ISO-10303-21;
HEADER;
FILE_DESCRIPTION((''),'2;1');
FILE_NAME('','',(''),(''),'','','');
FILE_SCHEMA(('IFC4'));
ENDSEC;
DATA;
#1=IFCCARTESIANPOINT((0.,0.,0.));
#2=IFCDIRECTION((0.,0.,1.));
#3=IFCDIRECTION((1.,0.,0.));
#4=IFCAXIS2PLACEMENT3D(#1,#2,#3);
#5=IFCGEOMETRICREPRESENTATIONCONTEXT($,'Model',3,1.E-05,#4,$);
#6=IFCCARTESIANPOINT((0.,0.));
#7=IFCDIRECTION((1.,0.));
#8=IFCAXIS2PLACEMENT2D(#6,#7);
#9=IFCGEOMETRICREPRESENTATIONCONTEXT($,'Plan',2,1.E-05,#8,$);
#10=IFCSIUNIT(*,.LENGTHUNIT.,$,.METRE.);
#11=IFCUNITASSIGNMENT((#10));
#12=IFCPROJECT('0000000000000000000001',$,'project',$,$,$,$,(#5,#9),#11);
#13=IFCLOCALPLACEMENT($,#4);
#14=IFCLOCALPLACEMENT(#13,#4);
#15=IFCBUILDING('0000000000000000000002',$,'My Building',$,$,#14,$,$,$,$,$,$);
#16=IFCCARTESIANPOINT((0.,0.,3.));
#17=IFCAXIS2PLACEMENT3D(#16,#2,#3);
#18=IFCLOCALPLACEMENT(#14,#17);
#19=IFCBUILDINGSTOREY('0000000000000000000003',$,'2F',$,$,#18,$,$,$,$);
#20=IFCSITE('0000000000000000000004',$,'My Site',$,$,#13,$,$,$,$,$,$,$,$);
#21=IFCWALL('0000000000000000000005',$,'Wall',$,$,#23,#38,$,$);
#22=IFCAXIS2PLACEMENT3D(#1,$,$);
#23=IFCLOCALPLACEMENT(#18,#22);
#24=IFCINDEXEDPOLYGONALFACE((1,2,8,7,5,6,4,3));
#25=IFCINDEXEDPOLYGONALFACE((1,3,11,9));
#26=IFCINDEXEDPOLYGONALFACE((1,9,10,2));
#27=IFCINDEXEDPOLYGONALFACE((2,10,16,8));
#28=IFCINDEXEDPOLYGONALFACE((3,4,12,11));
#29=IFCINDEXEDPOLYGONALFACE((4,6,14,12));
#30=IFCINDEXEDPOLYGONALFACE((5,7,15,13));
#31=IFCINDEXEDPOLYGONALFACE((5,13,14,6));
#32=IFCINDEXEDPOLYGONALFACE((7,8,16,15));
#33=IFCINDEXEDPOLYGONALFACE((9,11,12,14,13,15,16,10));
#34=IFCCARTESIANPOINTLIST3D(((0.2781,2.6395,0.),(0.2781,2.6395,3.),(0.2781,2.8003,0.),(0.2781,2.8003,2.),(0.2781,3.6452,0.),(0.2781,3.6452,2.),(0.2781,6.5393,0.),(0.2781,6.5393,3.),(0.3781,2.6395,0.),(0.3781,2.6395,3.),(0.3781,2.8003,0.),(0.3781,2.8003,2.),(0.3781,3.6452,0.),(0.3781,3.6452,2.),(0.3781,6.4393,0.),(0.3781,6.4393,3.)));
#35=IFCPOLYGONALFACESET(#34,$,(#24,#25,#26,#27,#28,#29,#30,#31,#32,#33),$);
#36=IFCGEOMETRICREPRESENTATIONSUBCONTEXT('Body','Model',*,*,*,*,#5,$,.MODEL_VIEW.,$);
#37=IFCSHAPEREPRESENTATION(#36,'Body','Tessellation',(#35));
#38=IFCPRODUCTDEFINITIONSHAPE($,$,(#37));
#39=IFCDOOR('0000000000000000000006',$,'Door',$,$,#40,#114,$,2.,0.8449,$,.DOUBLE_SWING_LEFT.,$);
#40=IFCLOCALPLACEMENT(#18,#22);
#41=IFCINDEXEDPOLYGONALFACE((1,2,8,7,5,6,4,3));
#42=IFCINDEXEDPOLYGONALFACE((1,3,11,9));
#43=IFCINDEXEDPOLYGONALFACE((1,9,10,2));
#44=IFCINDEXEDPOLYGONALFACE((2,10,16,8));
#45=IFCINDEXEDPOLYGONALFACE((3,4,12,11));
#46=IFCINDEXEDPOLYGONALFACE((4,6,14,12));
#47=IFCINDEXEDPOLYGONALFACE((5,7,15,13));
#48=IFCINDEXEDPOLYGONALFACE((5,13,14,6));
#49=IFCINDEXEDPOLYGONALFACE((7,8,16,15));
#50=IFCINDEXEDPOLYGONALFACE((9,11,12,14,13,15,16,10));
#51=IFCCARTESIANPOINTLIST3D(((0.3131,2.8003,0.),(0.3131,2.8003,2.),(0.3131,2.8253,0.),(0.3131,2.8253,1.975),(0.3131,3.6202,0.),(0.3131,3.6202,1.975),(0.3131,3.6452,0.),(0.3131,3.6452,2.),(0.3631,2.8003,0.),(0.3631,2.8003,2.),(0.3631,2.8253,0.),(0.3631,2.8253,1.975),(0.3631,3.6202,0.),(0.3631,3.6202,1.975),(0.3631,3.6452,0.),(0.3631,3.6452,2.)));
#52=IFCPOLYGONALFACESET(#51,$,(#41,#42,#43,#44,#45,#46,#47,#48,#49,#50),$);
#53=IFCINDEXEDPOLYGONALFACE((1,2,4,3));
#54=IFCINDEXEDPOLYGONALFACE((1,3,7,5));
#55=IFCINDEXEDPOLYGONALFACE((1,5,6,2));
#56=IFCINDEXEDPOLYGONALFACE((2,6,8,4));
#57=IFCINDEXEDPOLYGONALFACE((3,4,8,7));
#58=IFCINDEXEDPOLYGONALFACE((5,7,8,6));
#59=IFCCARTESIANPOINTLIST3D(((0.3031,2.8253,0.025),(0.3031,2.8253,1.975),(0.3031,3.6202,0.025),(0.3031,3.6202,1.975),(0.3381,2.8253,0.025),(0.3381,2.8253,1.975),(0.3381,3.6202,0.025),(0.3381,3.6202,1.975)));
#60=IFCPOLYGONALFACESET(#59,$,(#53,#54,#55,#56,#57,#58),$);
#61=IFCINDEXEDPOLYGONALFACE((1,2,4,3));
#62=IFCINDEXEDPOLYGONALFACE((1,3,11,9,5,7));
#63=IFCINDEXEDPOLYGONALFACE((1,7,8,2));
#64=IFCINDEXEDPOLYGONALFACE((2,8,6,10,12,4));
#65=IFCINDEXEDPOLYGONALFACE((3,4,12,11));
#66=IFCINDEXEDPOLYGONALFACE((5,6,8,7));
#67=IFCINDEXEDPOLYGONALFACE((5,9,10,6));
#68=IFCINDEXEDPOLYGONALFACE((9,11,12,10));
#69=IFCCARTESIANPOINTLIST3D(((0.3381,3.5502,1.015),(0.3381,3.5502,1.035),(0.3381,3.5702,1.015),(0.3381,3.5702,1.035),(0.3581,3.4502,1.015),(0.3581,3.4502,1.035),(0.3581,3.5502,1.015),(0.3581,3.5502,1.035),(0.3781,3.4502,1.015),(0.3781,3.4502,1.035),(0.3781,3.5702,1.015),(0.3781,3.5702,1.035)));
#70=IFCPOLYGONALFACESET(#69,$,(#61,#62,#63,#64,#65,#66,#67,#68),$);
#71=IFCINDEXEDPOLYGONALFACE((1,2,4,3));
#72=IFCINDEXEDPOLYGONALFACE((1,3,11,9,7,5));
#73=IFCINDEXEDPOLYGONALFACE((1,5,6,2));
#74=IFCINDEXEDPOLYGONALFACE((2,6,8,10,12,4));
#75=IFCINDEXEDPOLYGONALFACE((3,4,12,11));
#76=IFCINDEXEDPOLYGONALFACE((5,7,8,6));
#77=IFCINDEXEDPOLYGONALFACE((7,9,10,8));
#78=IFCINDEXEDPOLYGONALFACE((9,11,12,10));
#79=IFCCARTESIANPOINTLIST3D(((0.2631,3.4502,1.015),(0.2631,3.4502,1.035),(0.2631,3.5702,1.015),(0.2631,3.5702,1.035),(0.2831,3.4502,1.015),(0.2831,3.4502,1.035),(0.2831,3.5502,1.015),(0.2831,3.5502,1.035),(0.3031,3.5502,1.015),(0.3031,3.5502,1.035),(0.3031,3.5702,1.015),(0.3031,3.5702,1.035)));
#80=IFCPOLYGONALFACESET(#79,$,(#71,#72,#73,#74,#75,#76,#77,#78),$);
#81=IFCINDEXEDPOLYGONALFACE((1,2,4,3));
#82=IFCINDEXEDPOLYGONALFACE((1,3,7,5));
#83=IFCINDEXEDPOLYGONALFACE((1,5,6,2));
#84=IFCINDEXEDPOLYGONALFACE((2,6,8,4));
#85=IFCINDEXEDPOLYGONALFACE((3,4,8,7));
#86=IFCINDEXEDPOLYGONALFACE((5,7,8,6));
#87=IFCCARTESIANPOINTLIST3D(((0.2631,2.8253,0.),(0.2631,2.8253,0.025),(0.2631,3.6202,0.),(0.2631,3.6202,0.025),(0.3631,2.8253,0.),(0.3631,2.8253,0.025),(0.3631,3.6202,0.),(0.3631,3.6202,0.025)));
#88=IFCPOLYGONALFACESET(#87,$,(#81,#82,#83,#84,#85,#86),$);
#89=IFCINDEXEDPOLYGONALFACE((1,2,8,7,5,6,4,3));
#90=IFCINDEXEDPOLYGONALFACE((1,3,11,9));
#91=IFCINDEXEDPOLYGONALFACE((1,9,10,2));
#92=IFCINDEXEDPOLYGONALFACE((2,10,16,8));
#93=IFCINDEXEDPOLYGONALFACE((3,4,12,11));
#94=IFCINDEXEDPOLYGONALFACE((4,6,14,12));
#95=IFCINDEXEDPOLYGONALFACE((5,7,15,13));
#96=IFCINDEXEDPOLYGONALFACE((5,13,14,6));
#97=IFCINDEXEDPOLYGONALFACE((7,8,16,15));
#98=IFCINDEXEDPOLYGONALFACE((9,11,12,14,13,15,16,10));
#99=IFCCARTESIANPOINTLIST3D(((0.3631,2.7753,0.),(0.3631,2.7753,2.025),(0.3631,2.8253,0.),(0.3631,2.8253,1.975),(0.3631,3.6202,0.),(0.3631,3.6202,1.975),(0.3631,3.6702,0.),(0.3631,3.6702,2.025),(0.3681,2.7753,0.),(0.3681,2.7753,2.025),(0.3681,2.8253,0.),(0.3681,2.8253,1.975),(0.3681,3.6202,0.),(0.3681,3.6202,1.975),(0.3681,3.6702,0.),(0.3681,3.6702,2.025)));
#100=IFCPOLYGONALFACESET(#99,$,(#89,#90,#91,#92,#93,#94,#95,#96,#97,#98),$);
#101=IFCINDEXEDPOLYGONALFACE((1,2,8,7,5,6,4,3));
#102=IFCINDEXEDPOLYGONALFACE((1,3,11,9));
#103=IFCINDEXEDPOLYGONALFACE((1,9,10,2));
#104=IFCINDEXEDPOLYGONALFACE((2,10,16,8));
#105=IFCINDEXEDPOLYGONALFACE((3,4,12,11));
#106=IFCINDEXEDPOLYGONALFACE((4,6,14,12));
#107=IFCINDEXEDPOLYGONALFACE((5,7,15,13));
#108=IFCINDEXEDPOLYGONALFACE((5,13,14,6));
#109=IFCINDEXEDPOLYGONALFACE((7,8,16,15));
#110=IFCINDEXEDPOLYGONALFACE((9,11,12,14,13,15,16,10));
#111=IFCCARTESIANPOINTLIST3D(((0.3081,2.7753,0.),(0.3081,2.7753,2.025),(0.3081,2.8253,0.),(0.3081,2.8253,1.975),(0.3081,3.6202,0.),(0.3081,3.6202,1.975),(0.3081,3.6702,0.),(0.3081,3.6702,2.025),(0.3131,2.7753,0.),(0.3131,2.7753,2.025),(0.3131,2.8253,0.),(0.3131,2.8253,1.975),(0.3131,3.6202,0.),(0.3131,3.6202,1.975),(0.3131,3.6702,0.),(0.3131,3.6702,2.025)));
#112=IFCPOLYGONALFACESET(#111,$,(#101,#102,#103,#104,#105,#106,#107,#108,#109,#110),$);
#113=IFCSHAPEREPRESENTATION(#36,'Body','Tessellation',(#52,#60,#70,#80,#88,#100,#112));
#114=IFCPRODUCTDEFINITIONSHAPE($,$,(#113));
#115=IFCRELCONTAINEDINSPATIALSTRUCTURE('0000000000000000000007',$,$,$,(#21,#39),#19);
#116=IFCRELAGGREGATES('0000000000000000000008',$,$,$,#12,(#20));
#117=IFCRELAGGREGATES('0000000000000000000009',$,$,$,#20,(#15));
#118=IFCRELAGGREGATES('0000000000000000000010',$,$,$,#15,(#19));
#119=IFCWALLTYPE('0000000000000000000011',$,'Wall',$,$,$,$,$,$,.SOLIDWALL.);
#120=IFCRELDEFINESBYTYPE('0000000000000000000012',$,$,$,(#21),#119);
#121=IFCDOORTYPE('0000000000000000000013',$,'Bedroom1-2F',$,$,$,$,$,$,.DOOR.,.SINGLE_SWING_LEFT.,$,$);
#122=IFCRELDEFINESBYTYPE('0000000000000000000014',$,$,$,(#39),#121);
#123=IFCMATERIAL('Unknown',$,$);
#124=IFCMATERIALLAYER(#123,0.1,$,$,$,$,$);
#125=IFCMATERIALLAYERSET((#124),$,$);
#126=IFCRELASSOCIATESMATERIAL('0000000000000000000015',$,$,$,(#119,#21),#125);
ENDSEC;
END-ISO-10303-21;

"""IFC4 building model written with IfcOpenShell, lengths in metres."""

from ifc_helpers import new_model, entity, si_unit, frame, origin_with_axes, origin_2d_with_axis, place, context, subcontext, project, spatial, line, indexed_curve, outline, extrude, shape, source, transform, mapped, material, layer, layer_set, layer_usage, type_object, type_shapes, element, fill, save


model = new_model("IFC4")

# Units and contexts
model_context = context("Model", 3, precision=1e-05, world=origin_with_axes())
plan_context = context("Plan", 2, precision=1e-05, world=origin_2d_with_axis())
body_context_1 = subcontext(model_context, "Body", "Model", "MODEL_VIEW")
body_context_2 = subcontext(plan_context, "Body", "Plan", "PLAN_VIEW")
ifc_project = project(units=[si_unit("LENGTHUNIT", "METRE")], contexts=[model_context, plan_context])

# Site, building, storey
site_placement = place(None, origin_with_axes())
site = spatial("IfcSite", under=ifc_project, at=site_placement, Name="My Site")
building_placement = place(site_placement, origin_with_axes())
building = spatial("IfcBuilding", under=site, at=building_placement, Name="My Building")
storey_placement = place(building_placement, frame((0.0, 0.0, 3.0), z_axis=(0.0, 0.0, 1.0), x_axis=(1.0, 0.0, 0.0)))
storey = spatial("IfcBuildingStorey", under=building, at=storey_placement, Name="2F")

# Shared definitions
ifc_material = material(Name="Unknown")
ifc_layer = layer(ifc_material, 0.1)
ifc_layer_set = layer_set([ifc_layer])
wall_type = type_object("IfcWallType", Name="Wall", PredefinedType="SOLIDWALL", material=ifc_layer_set)

# Wall, opening, door
ifc_layer_usage_1 = layer_usage(ifc_layer_set, "AXIS2", "POSITIVE", 0.0)
wall_1_placement = place(storey_placement, frame((0.2781, 6.5393, 0.0), z_axis=(0.0, 0.0, 1.0), x_axis=(0.0, -1.0, 0.0)))
wall_1 = element("IfcWall", 1, at=wall_1_placement, inside=storey, type_object=wall_type, material=ifc_layer_usage_1, Name="Wall", context=body_context_1, shape_type="SweptSolid", body=[
    extrude(outline(indexed_curve([(0.0, 0.0), (0.1, 0.1), (3.8998, 0.1), (3.8998, 0.0)], segments=[line(1, 2, 3, 4, 1)])), origin_with_axes(), (0.0, 0.0, 1.0), 3.0),
])
shared_shape_1 = source(origin_with_axes(), body_context_1, "Body", "SweptSolid", [
    extrude(outline(indexed_curve([(0.0, 0.0), (0.8449, 0.0), (0.8449, 2.0), (0.0, 2.0)], segments=[line(1, 2, 3, 4, 1)])), frame((0.0, -0.6, 0.0), z_axis=(0.0, -1.0, 0.0), x_axis=(1.0, 0.0, 0.0)), (0.0, 0.0, -1.0), 1.2),
])
opening_1_placement = place(wall_1_placement, frame((3.739, 0.085, 0.0), z_axis=(0.0, 0.0, 1.0), x_axis=(-1.0, 0.0, 0.0)))
opening_1 = element("IfcOpeningElement", 2, at=opening_1_placement, cuts=wall_1, PredefinedType="OPENING", context=body_context_1, shape_type="MappedRepresentation", body=[
    mapped(shared_shape_1, transform((0.0, 0.0, 0.0), x_axis=(1.0, 0.0, 0.0), y_axis=(0.0, 1.0, 0.0), z_axis=(0.0, 0.0, 1.0), scale=1.0)),
])
door_type_1 = type_object("IfcDoorType", Name="Bedroom1-2F", OperationType="SINGLE_SWING_LEFT", PredefinedType="DOOR")
shared_shape_2 = source(origin_with_axes(), body_context_1, "Body", "SweptSolid", [
    extrude(outline(indexed_curve([(0.0, 0.0), (0.0, 2.0), (0.8449, 2.0), (0.8449, 0.0), (0.8199, 0.0), (0.8199, 1.975), (0.025, 1.975), (0.025, 0.0)], segments=[line(1, 2, 3, 4, 5, 6, 7, 8, 1)])), frame((0.0, 0.0, 0.0), z_axis=(0.0, -1.0, 0.0), x_axis=(1.0, 0.0, 0.0)), (0.0, 0.0, -1.0), 0.05),
    extrude(outline(indexed_curve([(0.0, 0.0), (0.7949, 0.0), (0.7949, 0.035), (0.0, 0.035)], segments=[line(1, 2, 3, 4, 1)])), frame((0.025, 0.025, 0.025), z_axis=(0.0, 0.0, 1.0), x_axis=(1.0, 0.0, 0.0)), (0.0, 0.0, 1.0), 1.95),
    extrude(outline(indexed_curve([(0.0, 0.0), (0.0, -0.04), (-0.12, -0.04), (-0.12, -0.02), (-0.02, -0.02), (-0.02, 0.0)], segments=[line(1, 2, 3, 4, 5, 6, 1)])), frame((0.7699, 0.025, 1.015), z_axis=(0.0, 0.0, 1.0), x_axis=(1.0, 0.0, 0.0)), (0.0, 0.0, 1.0), 0.02),
    extrude(outline(indexed_curve([(0.0, 0.0), (0.0, 0.04), (-0.12, 0.04), (-0.12, 0.02), (-0.02, 0.02), (-0.02, 0.0)], segments=[line(1, 2, 3, 4, 5, 6, 1)])), frame((0.7699, 0.06, 1.015), z_axis=(0.0, 0.0, 1.0), x_axis=(1.0, 0.0, 0.0)), (0.0, 0.0, 1.0), 0.02),
    extrude(outline(indexed_curve([(0.0, 0.0), (0.7949, 0.0), (0.7949, 0.1), (0.0, 0.1)], segments=[line(1, 2, 3, 4, 1)])), frame((0.025, 0.0, 0.0), z_axis=(0.0, 0.0, 1.0), x_axis=(1.0, 0.0, 0.0)), (0.0, 0.0, 1.0), 0.025),
    extrude(outline(indexed_curve([(0.0, 0.0), (0.0, 2.025), (0.8949, 2.025), (0.8949, 0.0), (0.8449, 0.0), (0.8449, 1.975), (0.05, 1.975), (0.05, 0.0)], segments=[line(1, 2, 3, 4, 5, 6, 7, 8, 1)])), frame((-0.025, -0.005, 0.0), z_axis=(0.0, -1.0, 0.0), x_axis=(1.0, 0.0, 0.0)), (0.0, 0.0, -1.0), 0.005),
    extrude(outline(indexed_curve([(0.0, 0.0), (0.0, 2.025), (0.8949, 2.025), (0.8949, 0.0), (0.8449, 0.0), (0.8449, 1.975), (0.05, 1.975), (0.05, 0.0)], segments=[line(1, 2, 3, 4, 5, 6, 7, 8, 1)])), frame((-0.025, 0.05, 0.0), z_axis=(0.0, -1.0, 0.0), x_axis=(1.0, 0.0, 0.0)), (0.0, 0.0, -1.0), 0.005),
])
shared_shape_3 = source(origin_with_axes(), body_context_2, "Body", "Curve2D", [
    entity("IfcIndexedPolyCurve", entity("IfcCartesianPointList2D", [[0.0, 0.0], [0.025, 0.0], [0.025, 0.05], [0.0, 0.05]]), [entity("IfcLineIndex", [1, 2, 3, 4, 1])]),
    entity("IfcIndexedPolyCurve", entity("IfcCartesianPointList2D", [[0.8449, 0.0], [0.8199, 0.0], [0.8199, 0.05], [0.8449, 0.05]]), [entity("IfcLineIndex", [1, 2, 3, 4, 1])]),
    entity("IfcIndexedPolyCurve", entity("IfcCartesianPointList2D", [[0.025, 0.05], [0.025, -0.7449], [0.06, -0.7449]])),
    entity("IfcTrimmedCurve", entity("IfcEllipse", entity("IfcAxis2Placement2D", entity("IfcCartesianPoint", [0.06, 0.05]), entity("IfcDirection", [1.0, 0.0])), 0.7599, 0.7949), [entity("IfcCartesianPoint", [0.06, -0.7449])], [entity("IfcCartesianPoint", [0.06, 0.8449])], True, "CARTESIAN"),
    entity("IfcIndexedPolyCurve", entity("IfcCartesianPointList2D", [[0.025, 0.05], [0.06, 0.05], [0.06, 0.8449], [0.025, 0.8449]]), [entity("IfcLineIndex", [1, 2, 3, 4, 1])]),
])
type_shapes(door_type_1, [shared_shape_2, shared_shape_3])
door_1_placement = place(opening_1_placement, frame((0.0, 0.0, 0.0), z_axis=(0.0, 0.0, 1.0), x_axis=(1.0, 0.0, 0.0)))
door_1 = element("IfcDoor", 3, at=door_1_placement, inside=storey, type_object=door_type_1, Name="Door", OperationType="DOUBLE_SWING_LEFT", OverallHeight=2.0, OverallWidth=0.8449, shapes=[
    shape(body_context_1, "Body", "MappedRepresentation", [mapped(shared_shape_2, transform((0.0, 0.0, 0.0), x_axis=(1.0, 0.0, 0.0), y_axis=(0.0, 1.0, 0.0), z_axis=(0.0, 0.0, 1.0), scale=1.0))]),
    shape(body_context_2, "Body", "MappedRepresentation", [mapped(shared_shape_3, transform((0.0, 0.0, 0.0), x_axis=(1.0, 0.0, 0.0), y_axis=(0.0, 1.0, 0.0), z_axis=(0.0, 0.0, 1.0), scale=1.0))]),
])
fill(opening_1, door_1)

save(model, "model.ifc")
